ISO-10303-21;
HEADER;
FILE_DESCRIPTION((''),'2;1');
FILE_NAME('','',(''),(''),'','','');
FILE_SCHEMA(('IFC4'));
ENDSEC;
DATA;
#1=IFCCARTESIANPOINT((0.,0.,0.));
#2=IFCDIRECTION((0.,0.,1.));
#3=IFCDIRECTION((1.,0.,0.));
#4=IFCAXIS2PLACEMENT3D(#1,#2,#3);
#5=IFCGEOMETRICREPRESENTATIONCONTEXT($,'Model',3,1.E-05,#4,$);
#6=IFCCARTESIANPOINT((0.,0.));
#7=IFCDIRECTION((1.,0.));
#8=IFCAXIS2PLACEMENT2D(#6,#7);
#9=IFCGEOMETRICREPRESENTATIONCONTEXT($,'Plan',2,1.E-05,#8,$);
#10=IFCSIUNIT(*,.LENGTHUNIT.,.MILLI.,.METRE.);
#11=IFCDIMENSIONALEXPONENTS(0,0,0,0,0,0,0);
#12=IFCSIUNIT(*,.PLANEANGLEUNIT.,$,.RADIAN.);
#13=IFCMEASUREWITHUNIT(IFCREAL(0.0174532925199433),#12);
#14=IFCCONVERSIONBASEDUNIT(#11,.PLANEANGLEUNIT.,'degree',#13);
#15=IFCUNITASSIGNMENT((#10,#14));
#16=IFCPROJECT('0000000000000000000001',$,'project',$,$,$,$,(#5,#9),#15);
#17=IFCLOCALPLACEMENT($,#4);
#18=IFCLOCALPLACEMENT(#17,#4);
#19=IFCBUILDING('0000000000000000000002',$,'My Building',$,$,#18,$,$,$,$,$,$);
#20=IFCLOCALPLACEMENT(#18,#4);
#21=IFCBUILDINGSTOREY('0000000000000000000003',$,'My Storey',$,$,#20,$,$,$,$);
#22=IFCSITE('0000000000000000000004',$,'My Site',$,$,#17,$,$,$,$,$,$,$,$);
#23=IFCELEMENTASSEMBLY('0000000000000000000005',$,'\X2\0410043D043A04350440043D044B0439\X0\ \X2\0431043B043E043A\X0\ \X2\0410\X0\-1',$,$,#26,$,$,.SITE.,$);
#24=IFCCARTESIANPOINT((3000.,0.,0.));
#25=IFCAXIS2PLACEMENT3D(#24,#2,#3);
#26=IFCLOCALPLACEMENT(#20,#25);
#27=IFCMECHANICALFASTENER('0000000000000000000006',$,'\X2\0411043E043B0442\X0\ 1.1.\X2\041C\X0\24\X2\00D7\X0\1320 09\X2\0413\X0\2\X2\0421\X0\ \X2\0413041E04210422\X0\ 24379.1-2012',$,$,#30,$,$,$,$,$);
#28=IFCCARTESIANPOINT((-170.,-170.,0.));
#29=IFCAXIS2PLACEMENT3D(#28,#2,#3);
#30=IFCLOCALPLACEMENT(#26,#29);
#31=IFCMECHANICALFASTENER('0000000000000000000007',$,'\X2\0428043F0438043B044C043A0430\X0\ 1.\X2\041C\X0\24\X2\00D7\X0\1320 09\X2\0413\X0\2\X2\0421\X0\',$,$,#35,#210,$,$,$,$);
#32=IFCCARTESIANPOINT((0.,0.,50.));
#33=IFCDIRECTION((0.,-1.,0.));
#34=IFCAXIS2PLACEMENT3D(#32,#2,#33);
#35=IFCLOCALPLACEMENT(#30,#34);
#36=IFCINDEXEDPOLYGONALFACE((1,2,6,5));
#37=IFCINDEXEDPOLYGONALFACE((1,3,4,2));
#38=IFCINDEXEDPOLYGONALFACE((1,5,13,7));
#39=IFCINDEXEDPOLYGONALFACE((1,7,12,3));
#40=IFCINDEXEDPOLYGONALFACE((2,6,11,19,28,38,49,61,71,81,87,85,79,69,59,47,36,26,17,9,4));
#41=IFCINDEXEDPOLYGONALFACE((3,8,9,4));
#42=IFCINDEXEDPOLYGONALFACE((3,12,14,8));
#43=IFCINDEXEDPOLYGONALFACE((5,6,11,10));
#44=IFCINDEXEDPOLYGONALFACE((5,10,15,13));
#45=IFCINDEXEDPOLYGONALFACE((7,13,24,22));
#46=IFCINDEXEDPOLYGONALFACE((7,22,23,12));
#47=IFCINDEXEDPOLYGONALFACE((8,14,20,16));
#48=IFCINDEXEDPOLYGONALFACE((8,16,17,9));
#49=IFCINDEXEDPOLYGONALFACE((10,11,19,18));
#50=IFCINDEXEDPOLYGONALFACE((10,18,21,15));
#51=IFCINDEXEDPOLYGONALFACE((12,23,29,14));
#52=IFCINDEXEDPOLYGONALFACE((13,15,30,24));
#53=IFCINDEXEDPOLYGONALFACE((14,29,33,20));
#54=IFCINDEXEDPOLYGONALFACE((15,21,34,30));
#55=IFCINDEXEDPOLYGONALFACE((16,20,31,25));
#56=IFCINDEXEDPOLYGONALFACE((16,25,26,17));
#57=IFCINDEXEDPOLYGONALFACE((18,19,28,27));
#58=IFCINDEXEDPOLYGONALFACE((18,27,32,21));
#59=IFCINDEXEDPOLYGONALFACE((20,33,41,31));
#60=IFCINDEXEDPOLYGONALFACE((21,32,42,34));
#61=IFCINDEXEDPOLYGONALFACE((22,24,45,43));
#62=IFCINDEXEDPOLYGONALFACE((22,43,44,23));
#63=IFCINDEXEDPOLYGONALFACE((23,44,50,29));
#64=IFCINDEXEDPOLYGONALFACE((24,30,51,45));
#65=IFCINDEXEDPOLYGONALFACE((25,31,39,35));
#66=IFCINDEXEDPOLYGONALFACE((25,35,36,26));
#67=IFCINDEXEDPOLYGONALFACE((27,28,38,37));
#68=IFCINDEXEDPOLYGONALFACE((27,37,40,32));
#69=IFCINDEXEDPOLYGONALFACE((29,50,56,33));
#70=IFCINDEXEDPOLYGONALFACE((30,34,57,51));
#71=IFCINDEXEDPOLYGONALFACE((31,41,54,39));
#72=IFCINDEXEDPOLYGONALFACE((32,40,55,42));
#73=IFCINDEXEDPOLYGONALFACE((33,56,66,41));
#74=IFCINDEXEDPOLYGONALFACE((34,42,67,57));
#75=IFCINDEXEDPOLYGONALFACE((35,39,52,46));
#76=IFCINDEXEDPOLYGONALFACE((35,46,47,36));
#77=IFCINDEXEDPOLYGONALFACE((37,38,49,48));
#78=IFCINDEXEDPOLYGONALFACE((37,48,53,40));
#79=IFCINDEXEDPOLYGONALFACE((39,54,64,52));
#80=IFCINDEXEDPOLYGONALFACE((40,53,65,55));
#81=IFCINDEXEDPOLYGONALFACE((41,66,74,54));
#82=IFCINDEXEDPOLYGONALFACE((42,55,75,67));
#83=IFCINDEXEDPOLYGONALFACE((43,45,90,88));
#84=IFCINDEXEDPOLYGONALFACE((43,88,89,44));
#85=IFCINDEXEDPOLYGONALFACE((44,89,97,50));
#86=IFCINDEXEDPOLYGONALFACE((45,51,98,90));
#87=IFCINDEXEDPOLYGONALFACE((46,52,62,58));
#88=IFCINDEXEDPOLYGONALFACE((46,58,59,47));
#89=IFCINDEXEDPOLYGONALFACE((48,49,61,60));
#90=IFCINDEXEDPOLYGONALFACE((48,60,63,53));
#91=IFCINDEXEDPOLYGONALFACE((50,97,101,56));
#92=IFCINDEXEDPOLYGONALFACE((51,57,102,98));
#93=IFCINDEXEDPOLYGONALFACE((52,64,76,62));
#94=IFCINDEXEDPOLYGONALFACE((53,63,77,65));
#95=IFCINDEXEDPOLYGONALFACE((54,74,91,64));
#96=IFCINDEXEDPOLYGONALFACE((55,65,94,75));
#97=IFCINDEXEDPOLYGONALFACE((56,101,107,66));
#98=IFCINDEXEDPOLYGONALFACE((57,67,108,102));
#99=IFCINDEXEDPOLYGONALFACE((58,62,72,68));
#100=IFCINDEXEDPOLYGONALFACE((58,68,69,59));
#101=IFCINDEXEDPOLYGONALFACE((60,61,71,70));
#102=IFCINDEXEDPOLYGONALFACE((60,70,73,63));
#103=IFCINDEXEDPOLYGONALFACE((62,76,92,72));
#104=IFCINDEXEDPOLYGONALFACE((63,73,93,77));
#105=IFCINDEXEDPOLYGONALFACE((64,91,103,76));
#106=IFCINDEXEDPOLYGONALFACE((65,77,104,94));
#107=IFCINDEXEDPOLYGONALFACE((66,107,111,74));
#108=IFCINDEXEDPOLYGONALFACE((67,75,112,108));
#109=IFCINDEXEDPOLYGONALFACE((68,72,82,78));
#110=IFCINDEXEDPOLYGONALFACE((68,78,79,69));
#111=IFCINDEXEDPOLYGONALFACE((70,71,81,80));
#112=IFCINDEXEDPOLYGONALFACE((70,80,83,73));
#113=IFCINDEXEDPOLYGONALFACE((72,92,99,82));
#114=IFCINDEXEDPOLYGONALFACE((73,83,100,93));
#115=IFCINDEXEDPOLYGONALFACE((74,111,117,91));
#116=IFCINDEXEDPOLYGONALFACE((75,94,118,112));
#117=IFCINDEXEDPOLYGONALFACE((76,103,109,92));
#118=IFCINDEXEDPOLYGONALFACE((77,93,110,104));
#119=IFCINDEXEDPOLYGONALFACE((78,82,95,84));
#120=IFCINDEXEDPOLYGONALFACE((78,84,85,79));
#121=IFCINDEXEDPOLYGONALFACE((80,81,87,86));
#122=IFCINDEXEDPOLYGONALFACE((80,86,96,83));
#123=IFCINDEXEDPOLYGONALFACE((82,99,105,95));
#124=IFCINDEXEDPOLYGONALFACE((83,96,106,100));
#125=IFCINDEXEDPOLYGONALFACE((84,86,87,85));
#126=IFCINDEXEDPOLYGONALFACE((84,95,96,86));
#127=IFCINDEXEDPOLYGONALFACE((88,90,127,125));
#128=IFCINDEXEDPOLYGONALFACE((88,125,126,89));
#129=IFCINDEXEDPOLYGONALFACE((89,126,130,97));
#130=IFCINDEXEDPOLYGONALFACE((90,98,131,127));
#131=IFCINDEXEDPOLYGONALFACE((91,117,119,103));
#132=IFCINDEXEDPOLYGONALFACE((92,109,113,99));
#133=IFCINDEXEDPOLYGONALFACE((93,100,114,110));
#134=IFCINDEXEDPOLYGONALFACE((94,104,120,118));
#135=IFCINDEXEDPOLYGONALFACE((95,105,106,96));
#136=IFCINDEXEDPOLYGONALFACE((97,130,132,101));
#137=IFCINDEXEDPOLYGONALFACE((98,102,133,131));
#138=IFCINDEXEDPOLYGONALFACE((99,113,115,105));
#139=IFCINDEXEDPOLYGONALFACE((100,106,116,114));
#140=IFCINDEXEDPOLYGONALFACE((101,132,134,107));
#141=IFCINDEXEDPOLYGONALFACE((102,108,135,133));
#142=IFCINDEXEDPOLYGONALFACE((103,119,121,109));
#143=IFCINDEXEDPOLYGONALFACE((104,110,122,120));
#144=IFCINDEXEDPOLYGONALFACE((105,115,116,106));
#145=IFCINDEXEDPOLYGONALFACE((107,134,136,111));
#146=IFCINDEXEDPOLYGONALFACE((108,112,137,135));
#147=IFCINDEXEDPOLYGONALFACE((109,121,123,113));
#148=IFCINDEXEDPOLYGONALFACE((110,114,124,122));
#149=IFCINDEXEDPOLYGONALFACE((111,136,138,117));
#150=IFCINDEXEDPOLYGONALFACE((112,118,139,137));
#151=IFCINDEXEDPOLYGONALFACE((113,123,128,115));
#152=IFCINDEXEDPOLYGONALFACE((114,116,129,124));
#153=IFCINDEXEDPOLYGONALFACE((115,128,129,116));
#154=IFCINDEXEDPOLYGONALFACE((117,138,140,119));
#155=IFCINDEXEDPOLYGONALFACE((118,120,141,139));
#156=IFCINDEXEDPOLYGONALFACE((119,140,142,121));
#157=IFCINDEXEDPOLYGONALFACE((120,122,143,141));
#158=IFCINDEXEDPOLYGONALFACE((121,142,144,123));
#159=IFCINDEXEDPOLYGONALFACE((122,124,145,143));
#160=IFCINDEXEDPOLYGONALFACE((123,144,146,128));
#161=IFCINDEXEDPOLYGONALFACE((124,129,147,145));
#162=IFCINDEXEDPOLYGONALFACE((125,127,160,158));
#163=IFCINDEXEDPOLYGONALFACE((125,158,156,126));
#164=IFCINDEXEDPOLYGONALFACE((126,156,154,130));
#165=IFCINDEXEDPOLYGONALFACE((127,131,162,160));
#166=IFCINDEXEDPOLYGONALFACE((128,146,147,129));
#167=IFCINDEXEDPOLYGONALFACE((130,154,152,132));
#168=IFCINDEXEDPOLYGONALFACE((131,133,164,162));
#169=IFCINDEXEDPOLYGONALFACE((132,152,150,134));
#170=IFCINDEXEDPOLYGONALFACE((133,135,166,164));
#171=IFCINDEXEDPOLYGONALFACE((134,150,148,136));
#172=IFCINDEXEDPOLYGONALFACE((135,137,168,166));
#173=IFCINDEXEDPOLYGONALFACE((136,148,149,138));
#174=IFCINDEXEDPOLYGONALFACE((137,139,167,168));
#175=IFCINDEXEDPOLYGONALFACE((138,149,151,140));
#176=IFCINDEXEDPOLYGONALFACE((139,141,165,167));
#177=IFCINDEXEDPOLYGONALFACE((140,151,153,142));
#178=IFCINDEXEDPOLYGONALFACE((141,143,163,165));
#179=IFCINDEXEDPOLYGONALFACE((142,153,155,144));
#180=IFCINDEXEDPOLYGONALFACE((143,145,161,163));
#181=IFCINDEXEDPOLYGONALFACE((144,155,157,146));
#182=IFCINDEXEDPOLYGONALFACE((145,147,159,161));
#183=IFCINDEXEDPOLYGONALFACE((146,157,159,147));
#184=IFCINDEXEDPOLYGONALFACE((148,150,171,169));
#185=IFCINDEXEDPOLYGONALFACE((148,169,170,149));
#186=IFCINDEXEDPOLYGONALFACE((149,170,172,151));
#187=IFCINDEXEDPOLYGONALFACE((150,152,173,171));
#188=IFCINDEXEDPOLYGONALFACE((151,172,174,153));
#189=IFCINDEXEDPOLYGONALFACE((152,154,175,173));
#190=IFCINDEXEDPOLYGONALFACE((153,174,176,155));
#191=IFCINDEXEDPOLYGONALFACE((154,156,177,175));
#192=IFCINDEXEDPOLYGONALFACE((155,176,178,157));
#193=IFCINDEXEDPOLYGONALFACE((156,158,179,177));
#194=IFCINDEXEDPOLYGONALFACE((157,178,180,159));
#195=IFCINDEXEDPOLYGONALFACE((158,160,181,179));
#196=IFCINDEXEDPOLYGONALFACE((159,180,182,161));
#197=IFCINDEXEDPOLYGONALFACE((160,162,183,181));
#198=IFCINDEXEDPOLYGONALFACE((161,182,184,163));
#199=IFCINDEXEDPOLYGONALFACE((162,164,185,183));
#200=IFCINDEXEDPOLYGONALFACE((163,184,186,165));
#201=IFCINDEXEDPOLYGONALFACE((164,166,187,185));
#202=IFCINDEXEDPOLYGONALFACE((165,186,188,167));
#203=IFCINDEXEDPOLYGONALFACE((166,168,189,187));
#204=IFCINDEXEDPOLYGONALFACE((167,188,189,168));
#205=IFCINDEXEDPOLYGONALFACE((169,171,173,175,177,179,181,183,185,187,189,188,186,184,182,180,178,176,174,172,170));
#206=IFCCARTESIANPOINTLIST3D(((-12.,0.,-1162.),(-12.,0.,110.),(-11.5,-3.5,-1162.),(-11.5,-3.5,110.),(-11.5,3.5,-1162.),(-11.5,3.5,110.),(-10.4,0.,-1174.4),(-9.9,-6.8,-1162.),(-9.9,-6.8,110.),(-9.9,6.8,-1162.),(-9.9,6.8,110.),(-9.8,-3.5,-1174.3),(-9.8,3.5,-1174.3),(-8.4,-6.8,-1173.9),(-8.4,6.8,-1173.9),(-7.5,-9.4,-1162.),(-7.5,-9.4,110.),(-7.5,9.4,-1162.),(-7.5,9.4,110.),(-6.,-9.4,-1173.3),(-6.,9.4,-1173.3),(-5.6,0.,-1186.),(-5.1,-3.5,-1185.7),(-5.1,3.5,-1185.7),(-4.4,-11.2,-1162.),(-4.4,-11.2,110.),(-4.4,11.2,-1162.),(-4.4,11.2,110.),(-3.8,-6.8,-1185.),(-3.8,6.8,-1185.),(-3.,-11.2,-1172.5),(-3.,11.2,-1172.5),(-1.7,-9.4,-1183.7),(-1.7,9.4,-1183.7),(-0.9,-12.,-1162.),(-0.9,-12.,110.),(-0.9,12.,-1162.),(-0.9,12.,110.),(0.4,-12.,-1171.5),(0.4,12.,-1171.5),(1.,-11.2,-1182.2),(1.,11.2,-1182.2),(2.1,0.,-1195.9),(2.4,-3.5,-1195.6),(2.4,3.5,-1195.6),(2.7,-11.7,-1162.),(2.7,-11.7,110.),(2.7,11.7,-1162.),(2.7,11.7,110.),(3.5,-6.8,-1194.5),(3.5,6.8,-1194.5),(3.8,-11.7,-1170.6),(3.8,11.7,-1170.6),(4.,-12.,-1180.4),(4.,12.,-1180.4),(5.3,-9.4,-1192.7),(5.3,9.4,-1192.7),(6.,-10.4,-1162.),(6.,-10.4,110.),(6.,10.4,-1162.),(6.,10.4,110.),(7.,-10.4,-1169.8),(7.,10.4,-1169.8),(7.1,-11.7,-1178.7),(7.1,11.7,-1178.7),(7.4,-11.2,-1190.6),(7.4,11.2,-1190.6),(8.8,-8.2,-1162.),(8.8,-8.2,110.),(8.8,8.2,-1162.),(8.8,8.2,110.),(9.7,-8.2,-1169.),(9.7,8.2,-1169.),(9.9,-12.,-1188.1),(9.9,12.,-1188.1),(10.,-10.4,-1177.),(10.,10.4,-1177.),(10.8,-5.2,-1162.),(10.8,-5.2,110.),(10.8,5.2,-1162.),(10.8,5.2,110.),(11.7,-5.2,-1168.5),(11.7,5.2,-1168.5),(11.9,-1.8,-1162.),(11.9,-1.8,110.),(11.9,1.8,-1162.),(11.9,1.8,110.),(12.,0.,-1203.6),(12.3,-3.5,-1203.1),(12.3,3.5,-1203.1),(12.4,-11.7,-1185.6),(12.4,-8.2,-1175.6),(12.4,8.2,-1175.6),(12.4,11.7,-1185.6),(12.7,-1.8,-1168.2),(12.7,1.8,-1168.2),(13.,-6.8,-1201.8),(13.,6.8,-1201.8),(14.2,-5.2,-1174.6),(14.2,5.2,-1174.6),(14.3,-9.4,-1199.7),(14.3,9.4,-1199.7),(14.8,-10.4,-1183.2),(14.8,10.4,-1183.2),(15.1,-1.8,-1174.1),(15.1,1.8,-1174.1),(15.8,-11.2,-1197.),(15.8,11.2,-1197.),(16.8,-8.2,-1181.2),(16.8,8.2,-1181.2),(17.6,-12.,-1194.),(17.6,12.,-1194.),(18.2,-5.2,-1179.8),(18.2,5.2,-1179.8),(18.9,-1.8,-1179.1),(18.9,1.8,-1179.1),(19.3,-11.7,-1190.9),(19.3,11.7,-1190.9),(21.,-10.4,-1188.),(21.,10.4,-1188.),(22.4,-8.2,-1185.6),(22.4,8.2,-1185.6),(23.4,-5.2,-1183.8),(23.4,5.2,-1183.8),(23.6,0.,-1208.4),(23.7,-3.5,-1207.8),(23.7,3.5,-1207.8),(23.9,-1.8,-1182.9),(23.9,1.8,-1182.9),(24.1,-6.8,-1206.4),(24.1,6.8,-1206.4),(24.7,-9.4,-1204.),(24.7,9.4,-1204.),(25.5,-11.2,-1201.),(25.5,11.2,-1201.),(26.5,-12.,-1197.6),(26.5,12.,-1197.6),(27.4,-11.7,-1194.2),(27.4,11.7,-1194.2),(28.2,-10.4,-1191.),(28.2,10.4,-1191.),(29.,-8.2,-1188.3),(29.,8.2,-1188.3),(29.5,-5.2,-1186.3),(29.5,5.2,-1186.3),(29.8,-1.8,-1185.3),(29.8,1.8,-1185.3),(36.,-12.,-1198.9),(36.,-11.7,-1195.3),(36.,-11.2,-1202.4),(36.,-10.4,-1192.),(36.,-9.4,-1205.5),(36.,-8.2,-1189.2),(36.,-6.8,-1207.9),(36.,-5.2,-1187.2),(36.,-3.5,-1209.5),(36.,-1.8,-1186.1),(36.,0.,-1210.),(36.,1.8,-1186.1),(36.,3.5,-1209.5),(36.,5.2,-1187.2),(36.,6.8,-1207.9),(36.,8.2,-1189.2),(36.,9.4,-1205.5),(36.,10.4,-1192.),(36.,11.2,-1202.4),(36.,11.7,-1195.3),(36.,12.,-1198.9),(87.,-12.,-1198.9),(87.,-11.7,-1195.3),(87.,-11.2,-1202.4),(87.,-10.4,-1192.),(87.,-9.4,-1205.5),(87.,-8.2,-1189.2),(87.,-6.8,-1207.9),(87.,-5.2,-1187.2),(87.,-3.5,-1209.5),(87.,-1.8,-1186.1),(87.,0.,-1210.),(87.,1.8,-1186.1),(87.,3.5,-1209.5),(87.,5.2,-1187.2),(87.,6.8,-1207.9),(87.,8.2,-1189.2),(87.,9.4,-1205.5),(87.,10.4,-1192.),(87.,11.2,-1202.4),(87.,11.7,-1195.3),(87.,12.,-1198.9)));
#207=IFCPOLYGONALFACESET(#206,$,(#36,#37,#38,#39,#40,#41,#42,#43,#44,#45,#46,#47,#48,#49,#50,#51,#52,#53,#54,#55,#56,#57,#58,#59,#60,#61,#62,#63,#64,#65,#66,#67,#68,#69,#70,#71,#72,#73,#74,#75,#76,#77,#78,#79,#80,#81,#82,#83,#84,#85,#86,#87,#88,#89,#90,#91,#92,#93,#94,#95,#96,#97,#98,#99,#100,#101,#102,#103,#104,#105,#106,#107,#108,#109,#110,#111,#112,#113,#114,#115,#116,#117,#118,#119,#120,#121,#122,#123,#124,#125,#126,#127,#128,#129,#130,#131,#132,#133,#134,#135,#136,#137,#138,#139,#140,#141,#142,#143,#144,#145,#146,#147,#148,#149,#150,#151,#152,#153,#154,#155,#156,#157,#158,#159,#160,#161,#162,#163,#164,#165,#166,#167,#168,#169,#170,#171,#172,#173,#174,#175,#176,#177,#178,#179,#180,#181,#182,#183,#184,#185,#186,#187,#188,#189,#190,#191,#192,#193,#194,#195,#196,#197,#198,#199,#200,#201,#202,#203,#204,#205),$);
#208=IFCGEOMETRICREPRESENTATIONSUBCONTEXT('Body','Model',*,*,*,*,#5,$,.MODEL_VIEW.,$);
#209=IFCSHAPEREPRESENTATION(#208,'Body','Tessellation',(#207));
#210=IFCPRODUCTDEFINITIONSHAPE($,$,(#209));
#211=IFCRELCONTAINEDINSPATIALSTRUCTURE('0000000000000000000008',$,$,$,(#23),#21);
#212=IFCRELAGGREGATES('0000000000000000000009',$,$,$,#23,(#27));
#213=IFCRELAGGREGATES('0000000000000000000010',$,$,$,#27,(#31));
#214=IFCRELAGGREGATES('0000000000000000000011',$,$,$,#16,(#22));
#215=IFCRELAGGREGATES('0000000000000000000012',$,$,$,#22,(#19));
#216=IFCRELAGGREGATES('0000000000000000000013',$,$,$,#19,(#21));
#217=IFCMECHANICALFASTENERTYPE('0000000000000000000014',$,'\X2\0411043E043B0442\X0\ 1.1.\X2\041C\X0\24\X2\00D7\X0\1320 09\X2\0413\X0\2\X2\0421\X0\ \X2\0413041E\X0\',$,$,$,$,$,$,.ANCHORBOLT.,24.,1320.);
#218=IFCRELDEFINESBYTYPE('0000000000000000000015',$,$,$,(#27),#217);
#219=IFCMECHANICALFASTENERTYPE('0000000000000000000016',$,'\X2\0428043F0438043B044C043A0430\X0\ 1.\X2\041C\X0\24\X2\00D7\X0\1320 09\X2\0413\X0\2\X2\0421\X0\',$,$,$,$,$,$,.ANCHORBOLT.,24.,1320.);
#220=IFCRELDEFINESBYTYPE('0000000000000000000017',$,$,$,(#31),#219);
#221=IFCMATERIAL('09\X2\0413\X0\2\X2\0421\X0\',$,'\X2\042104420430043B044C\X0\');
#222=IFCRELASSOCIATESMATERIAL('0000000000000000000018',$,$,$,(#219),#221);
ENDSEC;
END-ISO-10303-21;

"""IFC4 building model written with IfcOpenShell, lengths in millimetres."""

from ifc_helpers import new_model, entity, si_unit, converted_unit, frame, origin_with_axes, origin_2d_with_axis, place, context, subcontext, project, spatial, source, transform, mapped, material, type_object, type_shapes, element, aggregate, save


model = new_model("IFC4")

# Units and contexts
model_context = context("Model", 3, precision=1e-05, world=origin_with_axes())
plan_context = context("Plan", 2, precision=1e-05, world=origin_2d_with_axis())
body_context = subcontext(model_context, "Body", "Model", "MODEL_VIEW")
ifc_project = project(units=[si_unit("LENGTHUNIT", "METRE", prefix="MILLI"), converted_unit("PLANEANGLEUNIT", "degree", entity("IfcReal", 0.0174532925199433), si_unit("PLANEANGLEUNIT", "RADIAN"), dimensions=[0, 0, 0, 0, 0, 0, 0])], contexts=[model_context, plan_context])

# Site, building, storey
site_placement = place(None, origin_with_axes())
site = spatial("IfcSite", under=ifc_project, at=site_placement, Name="My Site")
building_placement = place(site_placement, origin_with_axes())
building = spatial("IfcBuilding", under=site, at=building_placement, Name="My Building")
storey_placement = place(building_placement, origin_with_axes())
storey = spatial("IfcBuildingStorey", under=building, at=storey_placement, Name="My Storey")

# Element assembly, mechanical fasteners
ifc_material_1 = material(Name="09Г2С", Category="Сталь")
mechanical_fastener_type_1 = type_object("IfcMechanicalFastenerType", Name="Шпилька 1.М24×1320 09Г2С", NominalDiameter=24.0, NominalLength=1320.0, PredefinedType="ANCHORBOLT", material=ifc_material_1)
shared_shape_1 = source(frame((0.0, 0.0, 110.0), z_axis=(0.0, 0.0, 1.0), x_axis=(1.0, 0.0, 0.0)), body_context, "Body", "AdvancedSweptSolid", [
    entity("IfcSweptDiskSolid", entity("IfcIndexedPolyCurve", entity("IfcCartesianPointList3D", [[0.0, 0.0, 0.0], [0.0, 0.0, -1272.0], [10.5, 0.0, -1297.5], [36.0, 0.0, -1308.0], [87.0, 0.0, -1308.0]]), [entity("IfcLineIndex", [1, 2]), entity("IfcArcIndex", [2, 3, 4]), entity("IfcLineIndex", [4, 5])]), 12.0),
])
type_shapes(mechanical_fastener_type_1, [shared_shape_1])
mechanical_fastener_type_2 = type_object("IfcMechanicalFastenerType", Name="Болт 1.1.М24×1320 09Г2С ГО", NominalDiameter=24.0, NominalLength=1320.0, PredefinedType="ANCHORBOLT")
assembly_1_placement = place(storey_placement, frame((3000.0, 0.0, 0.0), z_axis=(0.0, 0.0, 1.0), x_axis=(1.0, 0.0, 0.0)))
assembly_1 = element("IfcElementAssembly", 1, at=assembly_1_placement, inside=storey, Name="Анкерный блок А-1", AssemblyPlace="SITE")
mechanical_fastener_1_placement = place(assembly_1_placement, frame((-170.0, -170.0, 0.0), z_axis=(0.0, 0.0, 1.0), x_axis=(1.0, 0.0, 0.0)))
mechanical_fastener_1 = element("IfcMechanicalFastener", 2, at=mechanical_fastener_1_placement, type_object=mechanical_fastener_type_2, Name="Болт 1.1.М24×1320 09Г2С ГОСТ 24379.1-2012")
aggregate(assembly_1, [mechanical_fastener_1])
mechanical_fastener_2_placement = place(mechanical_fastener_1_placement, frame((0.0, 0.0, 50.0), z_axis=(0.0, 0.0, 1.0), x_axis=(0.0, -1.0, 0.0)))
mechanical_fastener_2 = element("IfcMechanicalFastener", 3, at=mechanical_fastener_2_placement, type_object=mechanical_fastener_type_1, Name="Шпилька 1.М24×1320 09Г2С", context=body_context, shape_type="MappedRepresentation", body=[
    mapped(shared_shape_1, transform((0.0, 0.0, 0.0), x_axis=(1.0, 0.0, 0.0), y_axis=(0.0, 1.0, 0.0), z_axis=(0.0, 0.0, 1.0), scale=1.0)),
])

aggregate(mechanical_fastener_1, [mechanical_fastener_2])

save(model, "model.ifc")
